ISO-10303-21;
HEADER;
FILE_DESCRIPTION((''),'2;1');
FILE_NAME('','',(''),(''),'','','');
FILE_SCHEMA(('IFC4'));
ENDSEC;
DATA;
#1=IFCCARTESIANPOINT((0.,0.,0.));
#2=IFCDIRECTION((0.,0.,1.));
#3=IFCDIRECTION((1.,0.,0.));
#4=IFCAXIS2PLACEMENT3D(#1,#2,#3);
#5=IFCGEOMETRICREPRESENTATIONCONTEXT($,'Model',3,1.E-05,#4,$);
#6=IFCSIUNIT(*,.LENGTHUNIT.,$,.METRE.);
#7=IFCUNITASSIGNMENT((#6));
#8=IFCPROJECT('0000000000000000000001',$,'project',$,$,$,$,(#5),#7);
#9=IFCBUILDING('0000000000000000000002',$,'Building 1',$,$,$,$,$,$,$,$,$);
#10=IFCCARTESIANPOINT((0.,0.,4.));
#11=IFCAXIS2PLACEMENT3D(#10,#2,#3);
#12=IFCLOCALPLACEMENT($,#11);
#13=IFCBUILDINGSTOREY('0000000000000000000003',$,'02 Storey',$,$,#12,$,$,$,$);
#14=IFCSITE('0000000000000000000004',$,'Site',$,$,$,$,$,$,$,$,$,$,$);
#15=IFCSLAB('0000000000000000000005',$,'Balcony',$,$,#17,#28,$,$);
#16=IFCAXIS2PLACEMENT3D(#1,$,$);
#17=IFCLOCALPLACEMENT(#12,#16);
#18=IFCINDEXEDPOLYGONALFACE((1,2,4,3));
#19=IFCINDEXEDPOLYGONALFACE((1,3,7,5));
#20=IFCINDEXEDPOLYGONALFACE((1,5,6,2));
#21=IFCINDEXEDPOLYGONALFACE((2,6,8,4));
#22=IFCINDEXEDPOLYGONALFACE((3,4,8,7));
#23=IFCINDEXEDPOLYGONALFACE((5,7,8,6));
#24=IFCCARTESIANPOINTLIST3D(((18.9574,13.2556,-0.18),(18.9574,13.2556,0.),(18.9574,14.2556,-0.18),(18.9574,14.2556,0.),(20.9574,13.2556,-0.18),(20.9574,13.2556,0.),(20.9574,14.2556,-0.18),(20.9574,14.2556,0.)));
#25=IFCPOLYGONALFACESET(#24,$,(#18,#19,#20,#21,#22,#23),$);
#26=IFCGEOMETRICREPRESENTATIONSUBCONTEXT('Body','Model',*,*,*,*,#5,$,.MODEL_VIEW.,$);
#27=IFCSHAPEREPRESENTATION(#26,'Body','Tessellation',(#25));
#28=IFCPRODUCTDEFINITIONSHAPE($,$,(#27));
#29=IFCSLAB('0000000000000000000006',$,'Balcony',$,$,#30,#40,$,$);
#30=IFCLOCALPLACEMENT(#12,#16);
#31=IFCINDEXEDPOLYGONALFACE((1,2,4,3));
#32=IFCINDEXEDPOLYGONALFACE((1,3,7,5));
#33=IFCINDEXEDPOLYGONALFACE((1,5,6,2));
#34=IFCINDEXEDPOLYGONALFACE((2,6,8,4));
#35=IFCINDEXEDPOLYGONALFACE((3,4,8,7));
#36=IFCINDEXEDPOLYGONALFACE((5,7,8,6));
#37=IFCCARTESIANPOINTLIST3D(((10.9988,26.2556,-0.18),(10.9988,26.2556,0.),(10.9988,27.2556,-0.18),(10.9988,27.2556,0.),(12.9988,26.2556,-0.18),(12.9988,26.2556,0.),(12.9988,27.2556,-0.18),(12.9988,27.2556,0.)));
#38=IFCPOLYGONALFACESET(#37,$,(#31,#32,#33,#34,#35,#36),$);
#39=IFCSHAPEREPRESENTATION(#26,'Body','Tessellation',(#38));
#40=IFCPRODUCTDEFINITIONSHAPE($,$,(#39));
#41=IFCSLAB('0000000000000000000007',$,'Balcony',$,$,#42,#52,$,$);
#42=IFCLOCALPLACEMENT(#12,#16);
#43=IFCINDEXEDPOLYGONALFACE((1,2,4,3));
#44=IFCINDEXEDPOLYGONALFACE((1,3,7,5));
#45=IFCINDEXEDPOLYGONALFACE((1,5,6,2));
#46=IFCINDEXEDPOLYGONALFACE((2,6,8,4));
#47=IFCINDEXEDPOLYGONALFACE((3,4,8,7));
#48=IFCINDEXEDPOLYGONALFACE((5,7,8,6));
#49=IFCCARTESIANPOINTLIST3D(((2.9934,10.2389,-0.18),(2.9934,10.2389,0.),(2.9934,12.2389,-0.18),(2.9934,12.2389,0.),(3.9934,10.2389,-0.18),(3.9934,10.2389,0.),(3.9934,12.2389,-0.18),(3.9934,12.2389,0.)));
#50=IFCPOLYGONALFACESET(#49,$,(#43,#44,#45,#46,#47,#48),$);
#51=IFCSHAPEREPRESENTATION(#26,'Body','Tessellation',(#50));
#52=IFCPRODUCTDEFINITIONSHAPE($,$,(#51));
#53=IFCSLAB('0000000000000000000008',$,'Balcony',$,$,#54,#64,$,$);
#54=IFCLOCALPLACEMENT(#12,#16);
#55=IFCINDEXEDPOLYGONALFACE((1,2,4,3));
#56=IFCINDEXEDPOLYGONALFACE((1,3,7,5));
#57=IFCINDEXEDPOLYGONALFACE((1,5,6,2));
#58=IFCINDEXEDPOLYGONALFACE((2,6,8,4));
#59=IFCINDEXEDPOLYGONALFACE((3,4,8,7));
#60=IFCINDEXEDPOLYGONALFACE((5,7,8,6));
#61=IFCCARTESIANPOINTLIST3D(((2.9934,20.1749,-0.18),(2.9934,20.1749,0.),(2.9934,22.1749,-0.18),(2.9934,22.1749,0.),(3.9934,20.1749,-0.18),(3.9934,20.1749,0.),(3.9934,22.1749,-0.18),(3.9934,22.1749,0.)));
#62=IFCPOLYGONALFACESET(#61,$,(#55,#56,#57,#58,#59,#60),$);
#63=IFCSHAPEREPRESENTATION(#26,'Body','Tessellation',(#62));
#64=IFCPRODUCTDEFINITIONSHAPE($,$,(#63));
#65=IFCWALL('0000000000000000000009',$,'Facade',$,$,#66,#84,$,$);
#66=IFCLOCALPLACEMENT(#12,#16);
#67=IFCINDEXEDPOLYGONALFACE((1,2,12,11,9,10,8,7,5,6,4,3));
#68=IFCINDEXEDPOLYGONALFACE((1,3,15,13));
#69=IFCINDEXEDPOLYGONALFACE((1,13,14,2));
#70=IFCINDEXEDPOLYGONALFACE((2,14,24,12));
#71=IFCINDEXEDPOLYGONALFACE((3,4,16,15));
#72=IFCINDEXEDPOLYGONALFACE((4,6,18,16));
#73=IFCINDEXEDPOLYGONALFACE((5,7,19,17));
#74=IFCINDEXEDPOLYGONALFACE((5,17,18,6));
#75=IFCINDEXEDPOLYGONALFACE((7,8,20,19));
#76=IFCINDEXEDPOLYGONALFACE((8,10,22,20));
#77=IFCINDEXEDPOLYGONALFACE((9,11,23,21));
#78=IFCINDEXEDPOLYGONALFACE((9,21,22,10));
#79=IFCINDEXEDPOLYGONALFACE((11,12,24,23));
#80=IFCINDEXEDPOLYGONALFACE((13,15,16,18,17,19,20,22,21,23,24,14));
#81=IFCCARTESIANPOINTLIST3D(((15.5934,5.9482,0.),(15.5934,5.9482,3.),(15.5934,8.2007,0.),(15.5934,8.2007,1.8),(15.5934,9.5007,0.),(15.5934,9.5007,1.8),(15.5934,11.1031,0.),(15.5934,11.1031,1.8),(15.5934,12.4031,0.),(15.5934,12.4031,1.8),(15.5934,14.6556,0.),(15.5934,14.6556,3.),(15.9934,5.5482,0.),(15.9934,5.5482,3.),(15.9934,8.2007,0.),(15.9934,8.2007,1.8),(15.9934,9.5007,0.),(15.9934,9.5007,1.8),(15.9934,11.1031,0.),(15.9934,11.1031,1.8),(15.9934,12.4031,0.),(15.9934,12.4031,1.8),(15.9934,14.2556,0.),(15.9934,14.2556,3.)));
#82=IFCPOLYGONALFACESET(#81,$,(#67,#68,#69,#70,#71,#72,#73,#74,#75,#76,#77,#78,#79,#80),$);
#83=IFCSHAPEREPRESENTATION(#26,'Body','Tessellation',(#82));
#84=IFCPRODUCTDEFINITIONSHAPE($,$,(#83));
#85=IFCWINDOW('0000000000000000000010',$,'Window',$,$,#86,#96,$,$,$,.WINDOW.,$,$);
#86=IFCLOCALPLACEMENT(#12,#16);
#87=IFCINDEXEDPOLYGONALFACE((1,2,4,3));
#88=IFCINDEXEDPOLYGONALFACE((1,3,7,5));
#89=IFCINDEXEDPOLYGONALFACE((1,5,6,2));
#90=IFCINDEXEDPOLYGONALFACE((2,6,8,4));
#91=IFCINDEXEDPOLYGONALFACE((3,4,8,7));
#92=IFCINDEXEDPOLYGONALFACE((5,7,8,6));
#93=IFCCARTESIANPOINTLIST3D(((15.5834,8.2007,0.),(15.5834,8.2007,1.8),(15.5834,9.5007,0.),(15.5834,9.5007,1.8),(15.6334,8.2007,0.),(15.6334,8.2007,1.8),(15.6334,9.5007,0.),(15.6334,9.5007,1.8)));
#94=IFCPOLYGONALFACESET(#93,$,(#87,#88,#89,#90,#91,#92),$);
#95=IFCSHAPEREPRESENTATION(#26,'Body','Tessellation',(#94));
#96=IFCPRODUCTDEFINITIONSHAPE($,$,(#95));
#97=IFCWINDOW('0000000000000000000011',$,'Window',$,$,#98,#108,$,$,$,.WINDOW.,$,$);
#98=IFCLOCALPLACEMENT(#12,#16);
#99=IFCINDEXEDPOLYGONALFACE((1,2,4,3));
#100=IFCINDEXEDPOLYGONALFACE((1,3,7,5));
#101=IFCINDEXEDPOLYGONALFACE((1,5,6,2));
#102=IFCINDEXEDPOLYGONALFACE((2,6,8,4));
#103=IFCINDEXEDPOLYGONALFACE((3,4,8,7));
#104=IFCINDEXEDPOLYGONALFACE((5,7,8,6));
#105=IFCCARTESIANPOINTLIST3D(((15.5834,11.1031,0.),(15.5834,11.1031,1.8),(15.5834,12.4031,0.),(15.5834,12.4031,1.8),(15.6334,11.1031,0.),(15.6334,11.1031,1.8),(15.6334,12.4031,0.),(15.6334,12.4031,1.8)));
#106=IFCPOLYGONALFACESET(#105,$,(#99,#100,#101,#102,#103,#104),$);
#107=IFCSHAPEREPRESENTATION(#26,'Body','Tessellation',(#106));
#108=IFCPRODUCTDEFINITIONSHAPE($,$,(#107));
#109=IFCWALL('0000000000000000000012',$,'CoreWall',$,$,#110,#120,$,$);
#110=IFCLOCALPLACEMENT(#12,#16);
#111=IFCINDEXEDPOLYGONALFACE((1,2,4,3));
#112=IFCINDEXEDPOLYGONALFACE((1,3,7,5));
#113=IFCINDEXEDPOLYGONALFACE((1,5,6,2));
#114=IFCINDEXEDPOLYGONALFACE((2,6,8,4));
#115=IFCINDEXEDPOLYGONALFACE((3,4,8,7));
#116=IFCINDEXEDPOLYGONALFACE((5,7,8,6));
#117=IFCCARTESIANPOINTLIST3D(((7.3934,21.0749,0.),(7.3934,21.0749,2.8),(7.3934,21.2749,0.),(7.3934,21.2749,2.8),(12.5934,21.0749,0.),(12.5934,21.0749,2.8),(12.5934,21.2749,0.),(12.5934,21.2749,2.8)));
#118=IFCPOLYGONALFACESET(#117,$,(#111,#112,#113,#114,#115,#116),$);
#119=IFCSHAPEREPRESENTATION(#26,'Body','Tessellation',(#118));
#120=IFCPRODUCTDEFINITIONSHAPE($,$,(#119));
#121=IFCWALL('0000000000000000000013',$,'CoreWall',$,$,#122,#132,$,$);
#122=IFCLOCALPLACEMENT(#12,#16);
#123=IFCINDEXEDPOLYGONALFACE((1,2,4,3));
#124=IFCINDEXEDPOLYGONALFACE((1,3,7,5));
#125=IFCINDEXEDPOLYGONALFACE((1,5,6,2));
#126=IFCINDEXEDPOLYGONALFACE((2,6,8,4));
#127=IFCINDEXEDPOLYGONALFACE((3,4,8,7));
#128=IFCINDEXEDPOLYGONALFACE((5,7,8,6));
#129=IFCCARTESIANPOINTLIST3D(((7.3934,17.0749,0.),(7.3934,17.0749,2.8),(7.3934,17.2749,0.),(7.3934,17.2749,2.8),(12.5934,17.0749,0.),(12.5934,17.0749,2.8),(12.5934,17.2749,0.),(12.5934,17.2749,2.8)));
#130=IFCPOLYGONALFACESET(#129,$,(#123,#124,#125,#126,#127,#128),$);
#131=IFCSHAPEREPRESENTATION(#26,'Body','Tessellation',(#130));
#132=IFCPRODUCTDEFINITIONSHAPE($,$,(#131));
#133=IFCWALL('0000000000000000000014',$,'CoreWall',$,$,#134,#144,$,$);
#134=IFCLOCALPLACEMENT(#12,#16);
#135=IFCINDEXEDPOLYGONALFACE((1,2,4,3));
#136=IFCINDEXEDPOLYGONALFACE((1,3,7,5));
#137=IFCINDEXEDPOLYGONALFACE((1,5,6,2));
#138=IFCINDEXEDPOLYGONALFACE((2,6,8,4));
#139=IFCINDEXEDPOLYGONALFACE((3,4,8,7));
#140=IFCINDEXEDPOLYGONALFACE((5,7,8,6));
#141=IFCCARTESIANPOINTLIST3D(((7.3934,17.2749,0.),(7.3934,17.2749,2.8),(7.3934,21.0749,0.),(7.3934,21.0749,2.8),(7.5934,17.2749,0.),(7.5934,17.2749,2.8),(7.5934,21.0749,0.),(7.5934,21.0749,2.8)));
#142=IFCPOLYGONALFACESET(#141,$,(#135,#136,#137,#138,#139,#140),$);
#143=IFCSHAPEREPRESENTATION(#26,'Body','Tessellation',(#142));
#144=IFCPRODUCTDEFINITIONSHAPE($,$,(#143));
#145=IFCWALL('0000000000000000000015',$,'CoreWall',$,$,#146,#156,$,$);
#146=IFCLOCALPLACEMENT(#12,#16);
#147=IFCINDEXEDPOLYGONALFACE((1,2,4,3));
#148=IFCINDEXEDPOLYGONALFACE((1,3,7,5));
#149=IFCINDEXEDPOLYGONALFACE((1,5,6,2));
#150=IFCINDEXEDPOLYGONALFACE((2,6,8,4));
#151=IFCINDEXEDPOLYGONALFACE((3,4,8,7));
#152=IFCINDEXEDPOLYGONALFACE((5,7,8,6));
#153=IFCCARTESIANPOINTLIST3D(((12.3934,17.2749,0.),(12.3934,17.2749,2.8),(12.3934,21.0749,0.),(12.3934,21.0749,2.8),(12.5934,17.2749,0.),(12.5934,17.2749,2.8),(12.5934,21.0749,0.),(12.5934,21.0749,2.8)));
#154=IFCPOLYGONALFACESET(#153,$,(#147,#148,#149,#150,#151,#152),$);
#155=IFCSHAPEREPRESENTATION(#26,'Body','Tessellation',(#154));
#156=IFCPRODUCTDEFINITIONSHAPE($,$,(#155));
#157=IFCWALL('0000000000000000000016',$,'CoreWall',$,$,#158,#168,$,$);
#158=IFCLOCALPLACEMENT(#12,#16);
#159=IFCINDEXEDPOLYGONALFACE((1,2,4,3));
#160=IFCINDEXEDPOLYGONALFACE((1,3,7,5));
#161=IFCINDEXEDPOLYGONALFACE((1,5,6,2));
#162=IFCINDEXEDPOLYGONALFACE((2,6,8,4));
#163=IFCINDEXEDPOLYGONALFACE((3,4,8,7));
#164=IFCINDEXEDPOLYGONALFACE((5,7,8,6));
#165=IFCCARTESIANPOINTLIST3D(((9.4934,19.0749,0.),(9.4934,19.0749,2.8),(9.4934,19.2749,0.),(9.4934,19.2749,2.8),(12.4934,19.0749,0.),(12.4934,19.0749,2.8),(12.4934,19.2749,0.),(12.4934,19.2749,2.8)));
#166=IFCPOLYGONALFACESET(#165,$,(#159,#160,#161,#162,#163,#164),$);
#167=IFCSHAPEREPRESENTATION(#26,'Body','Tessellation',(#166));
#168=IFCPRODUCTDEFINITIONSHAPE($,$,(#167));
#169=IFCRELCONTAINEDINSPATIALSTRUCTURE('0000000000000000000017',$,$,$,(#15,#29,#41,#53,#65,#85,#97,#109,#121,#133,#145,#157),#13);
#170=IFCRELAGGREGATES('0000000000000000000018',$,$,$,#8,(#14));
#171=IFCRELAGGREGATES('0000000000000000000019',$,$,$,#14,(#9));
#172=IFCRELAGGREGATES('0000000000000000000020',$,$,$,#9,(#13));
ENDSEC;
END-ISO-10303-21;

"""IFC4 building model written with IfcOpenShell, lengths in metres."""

from ifc_helpers import new_model, si_unit, frame, origin_with_axes, place, context, subcontext, project, spatial, line, indexed_curve, outline, extrude, element, fill, save


model = new_model("IFC4")

# Units and contexts
model_context = context("Model", 3, precision=1e-05, world=origin_with_axes())
body_context = subcontext(model_context, "Body", "Model", "MODEL_VIEW")
ifc_project = project(units=[si_unit("LENGTHUNIT", "METRE")], contexts=[model_context])

# Site, building, storey
site = spatial("IfcSite", under=ifc_project, Name="Site")
building = spatial("IfcBuilding", under=site, Name="Building 1")
storey_placement = place(None, frame((0.0, 0.0, 4.0), z_axis=(0.0, 0.0, 1.0), x_axis=(1.0, 0.0, 0.0)))
storey = spatial("IfcBuildingStorey", under=building, at=storey_placement, Name="02 Storey")

# Slabs
slab_1_placement = place(storey_placement, origin_with_axes())
element("IfcSlab", 1, at=slab_1_placement, inside=storey, Name="Balcony", context=body_context, shape_type="SweptSolid", body=[
    extrude(outline(indexed_curve([(20.9574, 14.2556), (20.9574, 13.2556), (18.9574, 13.2556), (18.9574, 14.2556)], segments=[line(1, 2), line(2, 3), line(3, 4)])), origin_with_axes(), (0.0, 0.0, -1.0), 0.18),
])
slab_2_placement = place(storey_placement, origin_with_axes())
element("IfcSlab", 2, at=slab_2_placement, inside=storey, Name="Balcony", context=body_context, shape_type="SweptSolid", body=[
    extrude(outline(indexed_curve([(10.9988, 26.2556), (10.9988, 27.2556), (12.9988, 27.2556), (12.9988, 26.2556)], segments=[line(1, 2), line(2, 3), line(3, 4)])), origin_with_axes(), (0.0, 0.0, -1.0), 0.18),
])
slab_3_placement = place(storey_placement, origin_with_axes())
element("IfcSlab", 3, at=slab_3_placement, inside=storey, Name="Balcony", context=body_context, shape_type="SweptSolid", body=[
    extrude(outline(indexed_curve([(3.9934, 10.2389), (2.9934, 10.2389), (2.9934, 12.2389), (3.9934, 12.2389)], segments=[line(1, 2), line(2, 3), line(3, 4)])), origin_with_axes(), (0.0, 0.0, -1.0), 0.18),
])
slab_4_placement = place(storey_placement, origin_with_axes())
element("IfcSlab", 4, at=slab_4_placement, inside=storey, Name="Balcony", context=body_context, shape_type="SweptSolid", body=[
    extrude(outline(indexed_curve([(3.9934, 20.1749), (2.9934, 20.1749), (2.9934, 22.1749), (3.9934, 22.1749)], segments=[line(1, 2), line(2, 3), line(3, 4)])), origin_with_axes(), (0.0, 0.0, -1.0), 0.18),
])

# Wall, openings, windows
wall_1_placement = place(storey_placement, origin_with_axes())
wall_1 = element("IfcWall", 5, at=wall_1_placement, inside=storey, Name="Facade", context=body_context, shape_type="SweptSolid", body=[
    extrude(outline(indexed_curve([(15.5934, 5.9482), (15.5934, 14.6556), (15.9934, 14.2556), (15.9934, 5.5482)], segments=[line(1, 2), line(2, 3), line(3, 4)])), origin_with_axes(), (0.0, 0.0, 1.0), 3.0),
])
opening_1_placement = place(wall_1_placement, origin_with_axes())
opening_1 = element("IfcOpeningElement", 6, at=opening_1_placement, cuts=wall_1, context=body_context, shape_type="SweptSolid", body=[
    extrude(outline(indexed_curve([(16.0334, 8.2007), (15.5334, 8.2007), (15.5334, 9.5007), (16.0334, 9.5007)], segments=[line(1, 2), line(2, 3), line(3, 4)])), origin_with_axes(), (0.0, 0.0, 1.0), 1.8),
])
opening_2_placement = place(wall_1_placement, origin_with_axes())
opening_2 = element("IfcOpeningElement", 7, at=opening_2_placement, cuts=wall_1, context=body_context, shape_type="SweptSolid", body=[
    extrude(outline(indexed_curve([(16.0334, 11.1031), (15.5334, 11.1031), (15.5334, 12.4031), (16.0334, 12.4031)], segments=[line(1, 2), line(2, 3), line(3, 4)])), origin_with_axes(), (0.0, 0.0, 1.0), 1.8),
])
window_1_placement = place(storey_placement, origin_with_axes())
window_1 = element("IfcWindow", 8, at=window_1_placement, inside=storey, Name="Window", PredefinedType="WINDOW", context=body_context, shape_type="SweptSolid", body=[
    extrude(outline(indexed_curve([(15.6334, 8.2007), (15.5834, 8.2007), (15.5834, 9.5007), (15.6334, 9.5007)], segments=[line(1, 2), line(2, 3), line(3, 4)])), origin_with_axes(), (0.0, 0.0, 1.0), 1.8),
])
fill(opening_1, window_1)
window_2_placement = place(storey_placement, origin_with_axes())
window_2 = element("IfcWindow", 9, at=window_2_placement, inside=storey, Name="Window", PredefinedType="WINDOW", context=body_context, shape_type="SweptSolid", body=[
    extrude(outline(indexed_curve([(15.6334, 11.1031), (15.5834, 11.1031), (15.5834, 12.4031), (15.6334, 12.4031)], segments=[line(1, 2), line(2, 3), line(3, 4)])), origin_with_axes(), (0.0, 0.0, 1.0), 1.8),
])
fill(opening_2, window_2)

# Walls
wall_2_placement = place(storey_placement, origin_with_axes())
element("IfcWall", 10, at=wall_2_placement, inside=storey, Name="CoreWall", context=body_context, shape_type="SweptSolid", body=[
    extrude(outline(indexed_curve([(12.5934, 21.2749), (7.3934, 21.2749), (7.3934, 21.0749), (12.5934, 21.0749)], segments=[line(1, 2), line(2, 3), line(3, 4)])), origin_with_axes(), (0.0, 0.0, 1.0), 2.8),
])
wall_3_placement = place(storey_placement, origin_with_axes())
element("IfcWall", 11, at=wall_3_placement, inside=storey, Name="CoreWall", context=body_context, shape_type="SweptSolid", body=[
    extrude(outline(indexed_curve([(7.3934, 17.0749), (12.5934, 17.0749), (12.5934, 17.2749), (7.3934, 17.2749)], segments=[line(1, 2), line(2, 3), line(3, 4)])), origin_with_axes(), (0.0, 0.0, 1.0), 2.8),
])
wall_4_placement = place(storey_placement, origin_with_axes())
element("IfcWall", 12, at=wall_4_placement, inside=storey, Name="CoreWall", context=body_context, shape_type="SweptSolid", body=[
    extrude(outline(indexed_curve([(7.5934, 17.2749), (7.5934, 21.0749), (7.3934, 21.0749), (7.3934, 17.2749)], segments=[line(1, 2), line(2, 3), line(3, 4)])), origin_with_axes(), (0.0, 0.0, 1.0), 2.8),
])
wall_5_placement = place(storey_placement, origin_with_axes())
element("IfcWall", 13, at=wall_5_placement, inside=storey, Name="CoreWall", context=body_context, shape_type="SweptSolid", body=[
    extrude(outline(indexed_curve([(12.3934, 21.0749), (12.3934, 17.2749), (12.5934, 17.2749), (12.5934, 21.0749)], segments=[line(1, 2), line(2, 3), line(3, 4)])), origin_with_axes(), (0.0, 0.0, 1.0), 2.8),
])
wall_6_placement = place(storey_placement, origin_with_axes())
element("IfcWall", 14, at=wall_6_placement, inside=storey, Name="CoreWall", context=body_context, shape_type="SweptSolid", body=[
    extrude(outline(indexed_curve([(12.4934, 19.2749), (9.4934, 19.2749), (9.4934, 19.0749), (12.4934, 19.0749)], segments=[line(1, 2), line(2, 3), line(3, 4)])), origin_with_axes(), (0.0, 0.0, 1.0), 2.8),
])

save(model, "model.ifc")
